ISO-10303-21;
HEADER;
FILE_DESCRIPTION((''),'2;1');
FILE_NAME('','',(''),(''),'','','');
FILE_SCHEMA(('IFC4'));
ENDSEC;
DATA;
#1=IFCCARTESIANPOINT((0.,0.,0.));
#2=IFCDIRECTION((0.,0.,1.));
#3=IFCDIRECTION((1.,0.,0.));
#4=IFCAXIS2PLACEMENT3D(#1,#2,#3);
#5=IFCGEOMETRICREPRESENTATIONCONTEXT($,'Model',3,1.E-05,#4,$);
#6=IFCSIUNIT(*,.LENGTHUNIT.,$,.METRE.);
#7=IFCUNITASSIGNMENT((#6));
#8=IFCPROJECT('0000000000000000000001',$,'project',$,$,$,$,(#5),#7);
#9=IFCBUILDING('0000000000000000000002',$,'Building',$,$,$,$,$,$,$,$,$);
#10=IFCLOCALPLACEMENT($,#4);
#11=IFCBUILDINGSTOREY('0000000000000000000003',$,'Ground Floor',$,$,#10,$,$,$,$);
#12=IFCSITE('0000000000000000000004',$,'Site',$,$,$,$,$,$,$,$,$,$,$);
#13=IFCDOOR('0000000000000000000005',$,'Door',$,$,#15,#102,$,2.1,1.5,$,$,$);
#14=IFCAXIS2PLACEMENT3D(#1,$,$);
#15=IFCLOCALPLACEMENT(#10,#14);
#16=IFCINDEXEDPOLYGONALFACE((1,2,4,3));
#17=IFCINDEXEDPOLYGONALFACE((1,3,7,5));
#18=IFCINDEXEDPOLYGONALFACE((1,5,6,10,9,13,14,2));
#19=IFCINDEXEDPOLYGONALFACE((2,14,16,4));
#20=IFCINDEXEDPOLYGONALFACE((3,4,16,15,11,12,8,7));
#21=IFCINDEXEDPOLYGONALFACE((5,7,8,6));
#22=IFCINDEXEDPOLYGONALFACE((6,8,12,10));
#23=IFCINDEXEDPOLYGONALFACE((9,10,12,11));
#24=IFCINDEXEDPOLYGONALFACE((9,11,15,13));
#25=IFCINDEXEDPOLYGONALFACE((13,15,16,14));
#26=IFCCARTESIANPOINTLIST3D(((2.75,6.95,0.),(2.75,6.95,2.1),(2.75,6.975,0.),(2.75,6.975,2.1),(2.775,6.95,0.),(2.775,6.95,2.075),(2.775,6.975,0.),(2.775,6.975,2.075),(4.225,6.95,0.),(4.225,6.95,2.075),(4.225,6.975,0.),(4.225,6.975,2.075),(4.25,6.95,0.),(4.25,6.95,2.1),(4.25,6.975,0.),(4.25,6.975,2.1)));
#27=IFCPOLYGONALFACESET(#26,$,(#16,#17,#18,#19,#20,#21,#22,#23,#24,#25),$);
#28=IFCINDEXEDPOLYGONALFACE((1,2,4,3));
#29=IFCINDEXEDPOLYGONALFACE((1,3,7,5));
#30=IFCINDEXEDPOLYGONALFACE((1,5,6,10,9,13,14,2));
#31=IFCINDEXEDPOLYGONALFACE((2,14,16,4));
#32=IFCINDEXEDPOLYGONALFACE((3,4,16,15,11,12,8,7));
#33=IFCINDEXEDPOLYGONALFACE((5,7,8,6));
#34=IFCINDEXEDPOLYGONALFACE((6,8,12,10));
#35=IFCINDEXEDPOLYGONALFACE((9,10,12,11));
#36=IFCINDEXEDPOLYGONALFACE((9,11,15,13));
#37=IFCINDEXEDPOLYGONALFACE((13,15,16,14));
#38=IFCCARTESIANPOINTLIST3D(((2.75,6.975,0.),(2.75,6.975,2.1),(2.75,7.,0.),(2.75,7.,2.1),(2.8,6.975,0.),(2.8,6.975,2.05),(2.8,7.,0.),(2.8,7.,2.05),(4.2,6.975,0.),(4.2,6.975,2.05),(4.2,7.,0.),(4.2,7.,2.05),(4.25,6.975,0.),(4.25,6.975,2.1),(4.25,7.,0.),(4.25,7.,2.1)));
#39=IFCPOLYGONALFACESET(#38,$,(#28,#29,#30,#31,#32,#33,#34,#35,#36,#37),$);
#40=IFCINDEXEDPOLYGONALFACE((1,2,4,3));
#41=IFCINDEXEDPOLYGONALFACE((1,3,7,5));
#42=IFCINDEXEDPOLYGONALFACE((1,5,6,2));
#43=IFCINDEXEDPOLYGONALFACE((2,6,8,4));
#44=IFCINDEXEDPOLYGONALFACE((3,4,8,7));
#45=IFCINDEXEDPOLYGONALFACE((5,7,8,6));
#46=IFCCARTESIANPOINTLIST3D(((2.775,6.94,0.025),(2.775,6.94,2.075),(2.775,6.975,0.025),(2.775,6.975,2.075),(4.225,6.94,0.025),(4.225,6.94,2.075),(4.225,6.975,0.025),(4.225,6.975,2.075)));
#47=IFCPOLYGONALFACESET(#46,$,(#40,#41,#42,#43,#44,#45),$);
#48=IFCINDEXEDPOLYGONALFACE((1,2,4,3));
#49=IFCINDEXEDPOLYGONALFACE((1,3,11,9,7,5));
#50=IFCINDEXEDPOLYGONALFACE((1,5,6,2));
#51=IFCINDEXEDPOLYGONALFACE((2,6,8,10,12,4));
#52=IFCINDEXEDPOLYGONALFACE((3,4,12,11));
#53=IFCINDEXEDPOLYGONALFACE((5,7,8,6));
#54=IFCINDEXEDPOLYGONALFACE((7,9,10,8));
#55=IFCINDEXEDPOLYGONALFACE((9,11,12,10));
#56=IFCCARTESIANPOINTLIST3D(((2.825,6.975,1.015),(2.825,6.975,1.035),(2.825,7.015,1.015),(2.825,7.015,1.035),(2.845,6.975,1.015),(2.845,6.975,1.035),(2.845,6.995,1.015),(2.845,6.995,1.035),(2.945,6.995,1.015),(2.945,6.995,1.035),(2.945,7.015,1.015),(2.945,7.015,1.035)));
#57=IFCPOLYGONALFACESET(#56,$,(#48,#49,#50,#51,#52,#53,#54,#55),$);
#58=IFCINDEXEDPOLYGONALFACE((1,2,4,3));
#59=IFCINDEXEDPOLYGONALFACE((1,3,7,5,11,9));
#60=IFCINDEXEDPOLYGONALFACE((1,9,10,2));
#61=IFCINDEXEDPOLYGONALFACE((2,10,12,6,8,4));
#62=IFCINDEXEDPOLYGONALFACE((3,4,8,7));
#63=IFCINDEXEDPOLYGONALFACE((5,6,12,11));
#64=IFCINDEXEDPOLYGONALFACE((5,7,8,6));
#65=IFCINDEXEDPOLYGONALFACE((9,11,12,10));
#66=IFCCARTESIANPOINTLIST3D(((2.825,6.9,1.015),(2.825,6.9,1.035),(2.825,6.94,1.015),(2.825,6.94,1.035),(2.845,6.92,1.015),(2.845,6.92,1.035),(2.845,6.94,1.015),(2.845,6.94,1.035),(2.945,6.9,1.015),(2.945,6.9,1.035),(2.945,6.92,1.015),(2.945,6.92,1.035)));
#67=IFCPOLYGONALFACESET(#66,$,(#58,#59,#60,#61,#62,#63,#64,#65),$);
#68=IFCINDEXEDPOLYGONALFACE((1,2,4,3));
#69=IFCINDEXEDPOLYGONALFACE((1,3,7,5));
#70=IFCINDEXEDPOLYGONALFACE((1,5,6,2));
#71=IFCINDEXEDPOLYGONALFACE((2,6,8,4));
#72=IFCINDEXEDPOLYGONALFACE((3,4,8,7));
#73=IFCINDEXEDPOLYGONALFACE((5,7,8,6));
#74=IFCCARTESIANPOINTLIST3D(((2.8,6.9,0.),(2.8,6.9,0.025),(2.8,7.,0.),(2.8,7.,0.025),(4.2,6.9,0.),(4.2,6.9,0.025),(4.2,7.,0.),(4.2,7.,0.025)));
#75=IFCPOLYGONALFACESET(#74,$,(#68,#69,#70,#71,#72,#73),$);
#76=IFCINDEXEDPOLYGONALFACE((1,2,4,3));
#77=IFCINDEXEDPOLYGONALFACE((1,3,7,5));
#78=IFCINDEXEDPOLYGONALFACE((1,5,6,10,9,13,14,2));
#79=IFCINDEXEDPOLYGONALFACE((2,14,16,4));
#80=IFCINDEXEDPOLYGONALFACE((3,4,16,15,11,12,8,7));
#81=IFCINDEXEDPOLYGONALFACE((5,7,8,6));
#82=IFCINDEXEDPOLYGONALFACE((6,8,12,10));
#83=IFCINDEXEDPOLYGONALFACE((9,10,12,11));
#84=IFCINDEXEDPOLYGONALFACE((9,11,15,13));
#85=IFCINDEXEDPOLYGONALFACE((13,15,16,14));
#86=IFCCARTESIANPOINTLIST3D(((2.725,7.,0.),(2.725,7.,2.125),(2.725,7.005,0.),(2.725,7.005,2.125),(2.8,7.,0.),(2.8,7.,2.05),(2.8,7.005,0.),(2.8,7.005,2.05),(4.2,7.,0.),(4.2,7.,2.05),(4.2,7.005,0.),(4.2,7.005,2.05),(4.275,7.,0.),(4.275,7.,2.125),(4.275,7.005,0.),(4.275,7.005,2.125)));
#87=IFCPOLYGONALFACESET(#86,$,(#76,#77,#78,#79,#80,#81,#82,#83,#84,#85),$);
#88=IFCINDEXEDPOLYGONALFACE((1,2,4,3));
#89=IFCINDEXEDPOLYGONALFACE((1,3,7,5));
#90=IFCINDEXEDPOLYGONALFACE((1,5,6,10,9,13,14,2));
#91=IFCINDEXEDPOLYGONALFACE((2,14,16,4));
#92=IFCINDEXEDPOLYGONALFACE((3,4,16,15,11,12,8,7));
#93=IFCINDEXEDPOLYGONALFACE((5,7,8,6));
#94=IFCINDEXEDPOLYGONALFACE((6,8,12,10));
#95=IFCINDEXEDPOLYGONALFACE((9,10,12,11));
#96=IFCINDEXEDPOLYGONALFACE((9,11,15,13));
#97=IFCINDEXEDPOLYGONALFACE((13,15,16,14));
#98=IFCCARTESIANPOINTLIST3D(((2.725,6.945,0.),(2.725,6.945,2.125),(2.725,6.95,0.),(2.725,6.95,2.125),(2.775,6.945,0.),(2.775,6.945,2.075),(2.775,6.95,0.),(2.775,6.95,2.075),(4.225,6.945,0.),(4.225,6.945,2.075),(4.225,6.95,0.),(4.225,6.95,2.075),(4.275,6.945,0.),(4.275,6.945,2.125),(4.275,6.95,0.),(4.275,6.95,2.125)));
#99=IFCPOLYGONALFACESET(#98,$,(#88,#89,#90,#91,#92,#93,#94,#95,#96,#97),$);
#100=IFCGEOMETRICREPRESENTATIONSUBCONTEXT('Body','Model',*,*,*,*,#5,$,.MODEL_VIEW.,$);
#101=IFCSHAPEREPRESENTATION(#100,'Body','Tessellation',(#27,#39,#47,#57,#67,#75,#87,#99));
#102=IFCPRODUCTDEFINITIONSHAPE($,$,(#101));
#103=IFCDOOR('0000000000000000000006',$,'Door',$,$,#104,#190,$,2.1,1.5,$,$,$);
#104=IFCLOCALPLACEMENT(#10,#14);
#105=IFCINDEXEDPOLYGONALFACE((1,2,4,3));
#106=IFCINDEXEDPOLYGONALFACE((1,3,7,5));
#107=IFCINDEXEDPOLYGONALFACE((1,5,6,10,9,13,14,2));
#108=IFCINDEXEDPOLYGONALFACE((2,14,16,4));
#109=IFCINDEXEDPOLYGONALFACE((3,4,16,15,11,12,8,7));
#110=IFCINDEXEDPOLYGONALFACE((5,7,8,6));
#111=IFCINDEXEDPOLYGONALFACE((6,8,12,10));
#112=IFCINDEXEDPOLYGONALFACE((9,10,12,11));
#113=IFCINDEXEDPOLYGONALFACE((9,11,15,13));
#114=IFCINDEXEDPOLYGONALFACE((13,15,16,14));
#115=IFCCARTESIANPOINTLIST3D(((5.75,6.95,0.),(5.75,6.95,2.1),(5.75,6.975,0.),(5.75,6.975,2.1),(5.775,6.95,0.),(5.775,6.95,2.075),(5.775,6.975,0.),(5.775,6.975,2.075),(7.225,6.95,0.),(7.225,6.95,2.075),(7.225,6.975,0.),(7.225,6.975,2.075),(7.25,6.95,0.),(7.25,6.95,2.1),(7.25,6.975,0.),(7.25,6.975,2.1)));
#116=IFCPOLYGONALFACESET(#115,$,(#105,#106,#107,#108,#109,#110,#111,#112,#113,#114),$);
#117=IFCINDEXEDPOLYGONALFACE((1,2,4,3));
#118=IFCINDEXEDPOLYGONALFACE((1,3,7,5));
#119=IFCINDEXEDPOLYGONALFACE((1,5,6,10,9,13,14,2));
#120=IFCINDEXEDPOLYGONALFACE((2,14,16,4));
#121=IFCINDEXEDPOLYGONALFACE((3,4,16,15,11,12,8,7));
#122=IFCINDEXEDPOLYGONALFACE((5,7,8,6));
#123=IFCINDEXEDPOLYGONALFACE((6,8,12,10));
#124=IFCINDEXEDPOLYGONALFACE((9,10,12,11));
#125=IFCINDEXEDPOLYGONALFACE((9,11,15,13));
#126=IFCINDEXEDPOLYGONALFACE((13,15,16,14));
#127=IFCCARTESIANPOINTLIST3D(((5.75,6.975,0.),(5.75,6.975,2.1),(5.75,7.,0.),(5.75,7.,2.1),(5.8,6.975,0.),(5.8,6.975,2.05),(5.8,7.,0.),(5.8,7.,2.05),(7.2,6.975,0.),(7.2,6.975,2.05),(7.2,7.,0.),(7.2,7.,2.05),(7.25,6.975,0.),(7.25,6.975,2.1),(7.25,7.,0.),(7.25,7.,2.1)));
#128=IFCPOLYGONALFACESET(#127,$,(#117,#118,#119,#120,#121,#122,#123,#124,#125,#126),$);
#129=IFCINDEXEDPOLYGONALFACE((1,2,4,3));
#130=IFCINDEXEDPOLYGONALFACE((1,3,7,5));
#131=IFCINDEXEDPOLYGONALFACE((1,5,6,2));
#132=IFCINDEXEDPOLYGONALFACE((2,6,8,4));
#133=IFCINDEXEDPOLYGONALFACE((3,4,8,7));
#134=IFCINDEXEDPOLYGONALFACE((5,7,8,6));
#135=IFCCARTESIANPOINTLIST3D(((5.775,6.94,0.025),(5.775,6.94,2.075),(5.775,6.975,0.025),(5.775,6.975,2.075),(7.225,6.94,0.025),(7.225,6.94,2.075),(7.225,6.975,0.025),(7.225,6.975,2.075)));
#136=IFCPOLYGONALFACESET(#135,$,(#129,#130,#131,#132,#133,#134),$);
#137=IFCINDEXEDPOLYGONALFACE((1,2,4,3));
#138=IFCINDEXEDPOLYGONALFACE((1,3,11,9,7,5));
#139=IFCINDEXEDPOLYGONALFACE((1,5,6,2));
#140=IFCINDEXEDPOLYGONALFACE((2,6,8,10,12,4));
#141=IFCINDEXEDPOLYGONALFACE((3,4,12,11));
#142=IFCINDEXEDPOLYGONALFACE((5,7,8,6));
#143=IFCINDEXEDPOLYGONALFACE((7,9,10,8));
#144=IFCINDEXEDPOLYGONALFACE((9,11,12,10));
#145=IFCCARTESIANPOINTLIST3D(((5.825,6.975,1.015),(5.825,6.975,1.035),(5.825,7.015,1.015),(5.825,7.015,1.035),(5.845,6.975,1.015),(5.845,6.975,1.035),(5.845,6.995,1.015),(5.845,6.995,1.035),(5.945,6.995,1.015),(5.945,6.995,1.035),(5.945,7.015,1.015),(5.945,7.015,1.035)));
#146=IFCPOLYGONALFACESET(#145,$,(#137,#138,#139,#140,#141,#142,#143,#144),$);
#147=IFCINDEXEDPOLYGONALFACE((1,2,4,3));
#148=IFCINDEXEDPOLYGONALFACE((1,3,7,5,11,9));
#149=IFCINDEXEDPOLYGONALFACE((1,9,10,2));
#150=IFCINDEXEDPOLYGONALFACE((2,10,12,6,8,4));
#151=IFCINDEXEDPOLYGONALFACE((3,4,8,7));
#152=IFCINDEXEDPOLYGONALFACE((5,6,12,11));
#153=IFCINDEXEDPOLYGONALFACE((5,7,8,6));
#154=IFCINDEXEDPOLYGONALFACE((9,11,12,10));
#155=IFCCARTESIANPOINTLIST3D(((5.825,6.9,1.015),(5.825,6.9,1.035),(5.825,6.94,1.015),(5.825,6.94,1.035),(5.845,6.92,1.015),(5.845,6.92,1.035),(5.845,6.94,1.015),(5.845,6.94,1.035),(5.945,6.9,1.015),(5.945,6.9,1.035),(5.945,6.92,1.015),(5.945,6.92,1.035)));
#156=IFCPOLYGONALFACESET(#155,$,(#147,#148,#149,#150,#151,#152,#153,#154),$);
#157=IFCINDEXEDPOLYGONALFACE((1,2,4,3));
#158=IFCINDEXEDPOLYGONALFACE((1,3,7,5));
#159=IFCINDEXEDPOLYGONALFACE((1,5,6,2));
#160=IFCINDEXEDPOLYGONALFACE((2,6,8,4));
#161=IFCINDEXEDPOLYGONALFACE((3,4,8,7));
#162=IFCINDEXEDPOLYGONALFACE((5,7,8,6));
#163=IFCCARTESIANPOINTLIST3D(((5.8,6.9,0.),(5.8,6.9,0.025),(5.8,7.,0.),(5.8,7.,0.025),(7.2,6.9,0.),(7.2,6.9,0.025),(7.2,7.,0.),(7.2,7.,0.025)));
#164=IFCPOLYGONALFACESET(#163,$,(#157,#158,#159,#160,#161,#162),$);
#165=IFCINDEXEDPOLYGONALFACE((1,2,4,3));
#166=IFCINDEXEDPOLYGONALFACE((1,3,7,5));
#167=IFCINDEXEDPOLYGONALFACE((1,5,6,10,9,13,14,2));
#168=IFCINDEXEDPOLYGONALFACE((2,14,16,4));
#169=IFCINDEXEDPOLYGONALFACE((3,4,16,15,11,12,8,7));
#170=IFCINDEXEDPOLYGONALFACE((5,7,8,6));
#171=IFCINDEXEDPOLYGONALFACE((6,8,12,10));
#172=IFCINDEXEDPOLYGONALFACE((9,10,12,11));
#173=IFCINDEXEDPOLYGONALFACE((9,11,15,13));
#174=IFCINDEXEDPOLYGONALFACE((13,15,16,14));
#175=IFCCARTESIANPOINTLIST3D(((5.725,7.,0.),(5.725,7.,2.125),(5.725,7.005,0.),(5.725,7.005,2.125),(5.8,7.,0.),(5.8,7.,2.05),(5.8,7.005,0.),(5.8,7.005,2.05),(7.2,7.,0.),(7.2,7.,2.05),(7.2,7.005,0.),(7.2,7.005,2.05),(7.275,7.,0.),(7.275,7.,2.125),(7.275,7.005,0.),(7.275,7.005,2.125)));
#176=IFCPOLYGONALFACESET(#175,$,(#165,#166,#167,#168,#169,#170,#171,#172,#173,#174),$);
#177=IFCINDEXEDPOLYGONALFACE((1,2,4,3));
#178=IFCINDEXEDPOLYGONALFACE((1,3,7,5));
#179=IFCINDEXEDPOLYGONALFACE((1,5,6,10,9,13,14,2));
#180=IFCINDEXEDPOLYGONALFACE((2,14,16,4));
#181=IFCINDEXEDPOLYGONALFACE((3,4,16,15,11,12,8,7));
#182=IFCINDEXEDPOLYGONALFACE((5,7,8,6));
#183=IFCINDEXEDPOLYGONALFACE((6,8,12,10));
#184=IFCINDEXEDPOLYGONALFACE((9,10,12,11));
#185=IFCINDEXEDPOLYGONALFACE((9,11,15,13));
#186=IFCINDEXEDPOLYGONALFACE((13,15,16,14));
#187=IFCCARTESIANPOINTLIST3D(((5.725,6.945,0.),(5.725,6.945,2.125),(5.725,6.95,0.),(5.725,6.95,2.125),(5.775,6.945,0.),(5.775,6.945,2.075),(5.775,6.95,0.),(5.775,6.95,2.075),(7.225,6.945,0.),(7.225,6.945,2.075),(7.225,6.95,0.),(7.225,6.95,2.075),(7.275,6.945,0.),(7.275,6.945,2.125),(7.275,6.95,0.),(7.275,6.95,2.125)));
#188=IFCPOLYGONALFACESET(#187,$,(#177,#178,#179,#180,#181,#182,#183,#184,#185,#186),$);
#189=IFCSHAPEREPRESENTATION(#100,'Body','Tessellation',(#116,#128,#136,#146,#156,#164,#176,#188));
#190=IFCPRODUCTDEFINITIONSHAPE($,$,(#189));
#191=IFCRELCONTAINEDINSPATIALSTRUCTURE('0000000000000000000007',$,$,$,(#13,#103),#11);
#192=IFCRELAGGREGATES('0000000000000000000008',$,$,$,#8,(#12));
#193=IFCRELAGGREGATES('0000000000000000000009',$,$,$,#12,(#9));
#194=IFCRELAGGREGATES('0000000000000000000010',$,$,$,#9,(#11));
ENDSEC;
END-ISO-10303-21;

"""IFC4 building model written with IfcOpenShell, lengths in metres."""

from ifc_helpers import new_model, si_unit, frame, origin_with_axes, place, context, subcontext, project, spatial, line, indexed_curve, outline, extrude, element, save


model = new_model("IFC4")

# Units and contexts
model_context = context("Model", 3, precision=1e-05, world=origin_with_axes())
body_context = subcontext(model_context, "Body", "Model", "MODEL_VIEW")
ifc_project = project(units=[si_unit("LENGTHUNIT", "METRE")], contexts=[model_context])

# Site, building, storey
site = spatial("IfcSite", under=ifc_project, Name="Site")
building = spatial("IfcBuilding", under=site, Name="Building")
storey_placement = place(None, origin_with_axes())
storey = spatial("IfcBuildingStorey", under=building, at=storey_placement, Name="Ground Floor")

# Doors
door_1_placement = place(storey_placement, frame((4.25, 7.0, 0.0), z_axis=(0.0, 0.0, 1.0), x_axis=(-1.0, 0.0, 0.0)))
element("IfcDoor", 1, at=door_1_placement, inside=storey, Name="Door", OverallHeight=2.1, OverallWidth=1.5, context=body_context, shape_type="SweptSolid", body=[
    extrude(outline(indexed_curve([(0.0, 0.0), (0.0, 2.1), (1.5, 2.1), (1.5, 0.0), (1.475, 0.0), (1.475, 2.075), (0.025, 2.075), (0.025, 0.0)], segments=[line(1, 2, 3, 4, 5, 6, 7, 8, 1)])), frame((0.0, 0.025, 0.0), z_axis=(0.0, -1.0, 0.0), x_axis=(1.0, 0.0, 0.0)), (0.0, 0.0, -1.0), 0.025),
    extrude(outline(indexed_curve([(0.0, 0.0), (0.0, 2.1), (1.5, 2.1), (1.5, 0.0), (1.45, 0.0), (1.45, 2.05), (0.05, 2.05), (0.05, 0.0)], segments=[line(1, 2, 3, 4, 5, 6, 7, 8, 1)])), frame((0.0, 0.0, 0.0), z_axis=(0.0, -1.0, 0.0), x_axis=(1.0, 0.0, 0.0)), (0.0, 0.0, -1.0), 0.025),
    extrude(outline(indexed_curve([(0.0, 0.0), (1.45, 0.0), (1.45, 0.035), (0.0, 0.035)], segments=[line(1, 2, 3, 4, 1)])), frame((0.025, 0.025, 0.025), z_axis=(0.0, 0.0, 1.0), x_axis=(1.0, 0.0, 0.0)), (0.0, 0.0, 1.0), 2.05),
    extrude(outline(indexed_curve([(0.0, 0.0), (0.0, -0.04), (-0.12, -0.04), (-0.12, -0.02), (-0.02, -0.02), (-0.02, 0.0)], segments=[line(1, 2, 3, 4, 5, 6, 1)])), frame((1.425, 0.025, 1.015), z_axis=(0.0, 0.0, 1.0), x_axis=(1.0, 0.0, 0.0)), (0.0, 0.0, 1.0), 0.02),
    extrude(outline(indexed_curve([(0.0, 0.0), (0.0, 0.04), (-0.12, 0.04), (-0.12, 0.02), (-0.02, 0.02), (-0.02, 0.0)], segments=[line(1, 2, 3, 4, 5, 6, 1)])), frame((1.425, 0.06, 1.015), z_axis=(0.0, 0.0, 1.0), x_axis=(1.0, 0.0, 0.0)), (0.0, 0.0, 1.0), 0.02),
    extrude(outline(indexed_curve([(0.0, 0.0), (1.4, 0.0), (1.4, 0.1), (0.0, 0.1)], segments=[line(1, 2, 3, 4, 1)])), frame((0.05, 0.0, 0.0), z_axis=(0.0, 0.0, 1.0), x_axis=(1.0, 0.0, 0.0)), (0.0, 0.0, 1.0), 0.025),
    extrude(outline(indexed_curve([(0.0, 0.0), (0.0, 2.125), (1.55, 2.125), (1.55, 0.0), (1.475, 0.0), (1.475, 2.05), (0.075, 2.05), (0.075, 0.0)], segments=[line(1, 2, 3, 4, 5, 6, 7, 8, 1)])), frame((-0.025, -0.005, 0.0), z_axis=(0.0, -1.0, 0.0), x_axis=(1.0, 0.0, 0.0)), (0.0, 0.0, -1.0), 0.005),
    extrude(outline(indexed_curve([(0.0, 0.0), (0.0, 2.125), (1.55, 2.125), (1.55, 0.0), (1.5, 0.0), (1.5, 2.075), (0.05, 2.075), (0.05, 0.0)], segments=[line(1, 2, 3, 4, 5, 6, 7, 8, 1)])), frame((-0.025, 0.05, 0.0), z_axis=(0.0, -1.0, 0.0), x_axis=(1.0, 0.0, 0.0)), (0.0, 0.0, -1.0), 0.005),
])
door_2_placement = place(storey_placement, frame((7.25, 7.0, 0.0), z_axis=(0.0, 0.0, 1.0), x_axis=(-1.0, 0.0, 0.0)))
element("IfcDoor", 2, at=door_2_placement, inside=storey, Name="Door", OverallHeight=2.1, OverallWidth=1.5, context=body_context, shape_type="SweptSolid", body=[
    extrude(outline(indexed_curve([(0.0, 0.0), (0.0, 2.1), (1.5, 2.1), (1.5, 0.0), (1.475, 0.0), (1.475, 2.075), (0.025, 2.075), (0.025, 0.0)], segments=[line(1, 2, 3, 4, 5, 6, 7, 8, 1)])), frame((0.0, 0.025, 0.0), z_axis=(0.0, -1.0, 0.0), x_axis=(1.0, 0.0, 0.0)), (0.0, 0.0, -1.0), 0.025),
    extrude(outline(indexed_curve([(0.0, 0.0), (0.0, 2.1), (1.5, 2.1), (1.5, 0.0), (1.45, 0.0), (1.45, 2.05), (0.05, 2.05), (0.05, 0.0)], segments=[line(1, 2, 3, 4, 5, 6, 7, 8, 1)])), frame((0.0, 0.0, 0.0), z_axis=(0.0, -1.0, 0.0), x_axis=(1.0, 0.0, 0.0)), (0.0, 0.0, -1.0), 0.025),
    extrude(outline(indexed_curve([(0.0, 0.0), (1.45, 0.0), (1.45, 0.035), (0.0, 0.035)], segments=[line(1, 2, 3, 4, 1)])), frame((0.025, 0.025, 0.025), z_axis=(0.0, 0.0, 1.0), x_axis=(1.0, 0.0, 0.0)), (0.0, 0.0, 1.0), 2.05),
    extrude(outline(indexed_curve([(0.0, 0.0), (0.0, -0.04), (-0.12, -0.04), (-0.12, -0.02), (-0.02, -0.02), (-0.02, 0.0)], segments=[line(1, 2, 3, 4, 5, 6, 1)])), frame((1.425, 0.025, 1.015), z_axis=(0.0, 0.0, 1.0), x_axis=(1.0, 0.0, 0.0)), (0.0, 0.0, 1.0), 0.02),
    extrude(outline(indexed_curve([(0.0, 0.0), (0.0, 0.04), (-0.12, 0.04), (-0.12, 0.02), (-0.02, 0.02), (-0.02, 0.0)], segments=[line(1, 2, 3, 4, 5, 6, 1)])), frame((1.425, 0.06, 1.015), z_axis=(0.0, 0.0, 1.0), x_axis=(1.0, 0.0, 0.0)), (0.0, 0.0, 1.0), 0.02),
    extrude(outline(indexed_curve([(0.0, 0.0), (1.4, 0.0), (1.4, 0.1), (0.0, 0.1)], segments=[line(1, 2, 3, 4, 1)])), frame((0.05, 0.0, 0.0), z_axis=(0.0, 0.0, 1.0), x_axis=(1.0, 0.0, 0.0)), (0.0, 0.0, 1.0), 0.025),
    extrude(outline(indexed_curve([(0.0, 0.0), (0.0, 2.125), (1.55, 2.125), (1.55, 0.0), (1.475, 0.0), (1.475, 2.05), (0.075, 2.05), (0.075, 0.0)], segments=[line(1, 2, 3, 4, 5, 6, 7, 8, 1)])), frame((-0.025, -0.005, 0.0), z_axis=(0.0, -1.0, 0.0), x_axis=(1.0, 0.0, 0.0)), (0.0, 0.0, -1.0), 0.005),
    extrude(outline(indexed_curve([(0.0, 0.0), (0.0, 2.125), (1.55, 2.125), (1.55, 0.0), (1.5, 0.0), (1.5, 2.075), (0.05, 2.075), (0.05, 0.0)], segments=[line(1, 2, 3, 4, 5, 6, 7, 8, 1)])), frame((-0.025, 0.05, 0.0), z_axis=(0.0, -1.0, 0.0), x_axis=(1.0, 0.0, 0.0)), (0.0, 0.0, -1.0), 0.005),
])

save(model, "model.ifc")
